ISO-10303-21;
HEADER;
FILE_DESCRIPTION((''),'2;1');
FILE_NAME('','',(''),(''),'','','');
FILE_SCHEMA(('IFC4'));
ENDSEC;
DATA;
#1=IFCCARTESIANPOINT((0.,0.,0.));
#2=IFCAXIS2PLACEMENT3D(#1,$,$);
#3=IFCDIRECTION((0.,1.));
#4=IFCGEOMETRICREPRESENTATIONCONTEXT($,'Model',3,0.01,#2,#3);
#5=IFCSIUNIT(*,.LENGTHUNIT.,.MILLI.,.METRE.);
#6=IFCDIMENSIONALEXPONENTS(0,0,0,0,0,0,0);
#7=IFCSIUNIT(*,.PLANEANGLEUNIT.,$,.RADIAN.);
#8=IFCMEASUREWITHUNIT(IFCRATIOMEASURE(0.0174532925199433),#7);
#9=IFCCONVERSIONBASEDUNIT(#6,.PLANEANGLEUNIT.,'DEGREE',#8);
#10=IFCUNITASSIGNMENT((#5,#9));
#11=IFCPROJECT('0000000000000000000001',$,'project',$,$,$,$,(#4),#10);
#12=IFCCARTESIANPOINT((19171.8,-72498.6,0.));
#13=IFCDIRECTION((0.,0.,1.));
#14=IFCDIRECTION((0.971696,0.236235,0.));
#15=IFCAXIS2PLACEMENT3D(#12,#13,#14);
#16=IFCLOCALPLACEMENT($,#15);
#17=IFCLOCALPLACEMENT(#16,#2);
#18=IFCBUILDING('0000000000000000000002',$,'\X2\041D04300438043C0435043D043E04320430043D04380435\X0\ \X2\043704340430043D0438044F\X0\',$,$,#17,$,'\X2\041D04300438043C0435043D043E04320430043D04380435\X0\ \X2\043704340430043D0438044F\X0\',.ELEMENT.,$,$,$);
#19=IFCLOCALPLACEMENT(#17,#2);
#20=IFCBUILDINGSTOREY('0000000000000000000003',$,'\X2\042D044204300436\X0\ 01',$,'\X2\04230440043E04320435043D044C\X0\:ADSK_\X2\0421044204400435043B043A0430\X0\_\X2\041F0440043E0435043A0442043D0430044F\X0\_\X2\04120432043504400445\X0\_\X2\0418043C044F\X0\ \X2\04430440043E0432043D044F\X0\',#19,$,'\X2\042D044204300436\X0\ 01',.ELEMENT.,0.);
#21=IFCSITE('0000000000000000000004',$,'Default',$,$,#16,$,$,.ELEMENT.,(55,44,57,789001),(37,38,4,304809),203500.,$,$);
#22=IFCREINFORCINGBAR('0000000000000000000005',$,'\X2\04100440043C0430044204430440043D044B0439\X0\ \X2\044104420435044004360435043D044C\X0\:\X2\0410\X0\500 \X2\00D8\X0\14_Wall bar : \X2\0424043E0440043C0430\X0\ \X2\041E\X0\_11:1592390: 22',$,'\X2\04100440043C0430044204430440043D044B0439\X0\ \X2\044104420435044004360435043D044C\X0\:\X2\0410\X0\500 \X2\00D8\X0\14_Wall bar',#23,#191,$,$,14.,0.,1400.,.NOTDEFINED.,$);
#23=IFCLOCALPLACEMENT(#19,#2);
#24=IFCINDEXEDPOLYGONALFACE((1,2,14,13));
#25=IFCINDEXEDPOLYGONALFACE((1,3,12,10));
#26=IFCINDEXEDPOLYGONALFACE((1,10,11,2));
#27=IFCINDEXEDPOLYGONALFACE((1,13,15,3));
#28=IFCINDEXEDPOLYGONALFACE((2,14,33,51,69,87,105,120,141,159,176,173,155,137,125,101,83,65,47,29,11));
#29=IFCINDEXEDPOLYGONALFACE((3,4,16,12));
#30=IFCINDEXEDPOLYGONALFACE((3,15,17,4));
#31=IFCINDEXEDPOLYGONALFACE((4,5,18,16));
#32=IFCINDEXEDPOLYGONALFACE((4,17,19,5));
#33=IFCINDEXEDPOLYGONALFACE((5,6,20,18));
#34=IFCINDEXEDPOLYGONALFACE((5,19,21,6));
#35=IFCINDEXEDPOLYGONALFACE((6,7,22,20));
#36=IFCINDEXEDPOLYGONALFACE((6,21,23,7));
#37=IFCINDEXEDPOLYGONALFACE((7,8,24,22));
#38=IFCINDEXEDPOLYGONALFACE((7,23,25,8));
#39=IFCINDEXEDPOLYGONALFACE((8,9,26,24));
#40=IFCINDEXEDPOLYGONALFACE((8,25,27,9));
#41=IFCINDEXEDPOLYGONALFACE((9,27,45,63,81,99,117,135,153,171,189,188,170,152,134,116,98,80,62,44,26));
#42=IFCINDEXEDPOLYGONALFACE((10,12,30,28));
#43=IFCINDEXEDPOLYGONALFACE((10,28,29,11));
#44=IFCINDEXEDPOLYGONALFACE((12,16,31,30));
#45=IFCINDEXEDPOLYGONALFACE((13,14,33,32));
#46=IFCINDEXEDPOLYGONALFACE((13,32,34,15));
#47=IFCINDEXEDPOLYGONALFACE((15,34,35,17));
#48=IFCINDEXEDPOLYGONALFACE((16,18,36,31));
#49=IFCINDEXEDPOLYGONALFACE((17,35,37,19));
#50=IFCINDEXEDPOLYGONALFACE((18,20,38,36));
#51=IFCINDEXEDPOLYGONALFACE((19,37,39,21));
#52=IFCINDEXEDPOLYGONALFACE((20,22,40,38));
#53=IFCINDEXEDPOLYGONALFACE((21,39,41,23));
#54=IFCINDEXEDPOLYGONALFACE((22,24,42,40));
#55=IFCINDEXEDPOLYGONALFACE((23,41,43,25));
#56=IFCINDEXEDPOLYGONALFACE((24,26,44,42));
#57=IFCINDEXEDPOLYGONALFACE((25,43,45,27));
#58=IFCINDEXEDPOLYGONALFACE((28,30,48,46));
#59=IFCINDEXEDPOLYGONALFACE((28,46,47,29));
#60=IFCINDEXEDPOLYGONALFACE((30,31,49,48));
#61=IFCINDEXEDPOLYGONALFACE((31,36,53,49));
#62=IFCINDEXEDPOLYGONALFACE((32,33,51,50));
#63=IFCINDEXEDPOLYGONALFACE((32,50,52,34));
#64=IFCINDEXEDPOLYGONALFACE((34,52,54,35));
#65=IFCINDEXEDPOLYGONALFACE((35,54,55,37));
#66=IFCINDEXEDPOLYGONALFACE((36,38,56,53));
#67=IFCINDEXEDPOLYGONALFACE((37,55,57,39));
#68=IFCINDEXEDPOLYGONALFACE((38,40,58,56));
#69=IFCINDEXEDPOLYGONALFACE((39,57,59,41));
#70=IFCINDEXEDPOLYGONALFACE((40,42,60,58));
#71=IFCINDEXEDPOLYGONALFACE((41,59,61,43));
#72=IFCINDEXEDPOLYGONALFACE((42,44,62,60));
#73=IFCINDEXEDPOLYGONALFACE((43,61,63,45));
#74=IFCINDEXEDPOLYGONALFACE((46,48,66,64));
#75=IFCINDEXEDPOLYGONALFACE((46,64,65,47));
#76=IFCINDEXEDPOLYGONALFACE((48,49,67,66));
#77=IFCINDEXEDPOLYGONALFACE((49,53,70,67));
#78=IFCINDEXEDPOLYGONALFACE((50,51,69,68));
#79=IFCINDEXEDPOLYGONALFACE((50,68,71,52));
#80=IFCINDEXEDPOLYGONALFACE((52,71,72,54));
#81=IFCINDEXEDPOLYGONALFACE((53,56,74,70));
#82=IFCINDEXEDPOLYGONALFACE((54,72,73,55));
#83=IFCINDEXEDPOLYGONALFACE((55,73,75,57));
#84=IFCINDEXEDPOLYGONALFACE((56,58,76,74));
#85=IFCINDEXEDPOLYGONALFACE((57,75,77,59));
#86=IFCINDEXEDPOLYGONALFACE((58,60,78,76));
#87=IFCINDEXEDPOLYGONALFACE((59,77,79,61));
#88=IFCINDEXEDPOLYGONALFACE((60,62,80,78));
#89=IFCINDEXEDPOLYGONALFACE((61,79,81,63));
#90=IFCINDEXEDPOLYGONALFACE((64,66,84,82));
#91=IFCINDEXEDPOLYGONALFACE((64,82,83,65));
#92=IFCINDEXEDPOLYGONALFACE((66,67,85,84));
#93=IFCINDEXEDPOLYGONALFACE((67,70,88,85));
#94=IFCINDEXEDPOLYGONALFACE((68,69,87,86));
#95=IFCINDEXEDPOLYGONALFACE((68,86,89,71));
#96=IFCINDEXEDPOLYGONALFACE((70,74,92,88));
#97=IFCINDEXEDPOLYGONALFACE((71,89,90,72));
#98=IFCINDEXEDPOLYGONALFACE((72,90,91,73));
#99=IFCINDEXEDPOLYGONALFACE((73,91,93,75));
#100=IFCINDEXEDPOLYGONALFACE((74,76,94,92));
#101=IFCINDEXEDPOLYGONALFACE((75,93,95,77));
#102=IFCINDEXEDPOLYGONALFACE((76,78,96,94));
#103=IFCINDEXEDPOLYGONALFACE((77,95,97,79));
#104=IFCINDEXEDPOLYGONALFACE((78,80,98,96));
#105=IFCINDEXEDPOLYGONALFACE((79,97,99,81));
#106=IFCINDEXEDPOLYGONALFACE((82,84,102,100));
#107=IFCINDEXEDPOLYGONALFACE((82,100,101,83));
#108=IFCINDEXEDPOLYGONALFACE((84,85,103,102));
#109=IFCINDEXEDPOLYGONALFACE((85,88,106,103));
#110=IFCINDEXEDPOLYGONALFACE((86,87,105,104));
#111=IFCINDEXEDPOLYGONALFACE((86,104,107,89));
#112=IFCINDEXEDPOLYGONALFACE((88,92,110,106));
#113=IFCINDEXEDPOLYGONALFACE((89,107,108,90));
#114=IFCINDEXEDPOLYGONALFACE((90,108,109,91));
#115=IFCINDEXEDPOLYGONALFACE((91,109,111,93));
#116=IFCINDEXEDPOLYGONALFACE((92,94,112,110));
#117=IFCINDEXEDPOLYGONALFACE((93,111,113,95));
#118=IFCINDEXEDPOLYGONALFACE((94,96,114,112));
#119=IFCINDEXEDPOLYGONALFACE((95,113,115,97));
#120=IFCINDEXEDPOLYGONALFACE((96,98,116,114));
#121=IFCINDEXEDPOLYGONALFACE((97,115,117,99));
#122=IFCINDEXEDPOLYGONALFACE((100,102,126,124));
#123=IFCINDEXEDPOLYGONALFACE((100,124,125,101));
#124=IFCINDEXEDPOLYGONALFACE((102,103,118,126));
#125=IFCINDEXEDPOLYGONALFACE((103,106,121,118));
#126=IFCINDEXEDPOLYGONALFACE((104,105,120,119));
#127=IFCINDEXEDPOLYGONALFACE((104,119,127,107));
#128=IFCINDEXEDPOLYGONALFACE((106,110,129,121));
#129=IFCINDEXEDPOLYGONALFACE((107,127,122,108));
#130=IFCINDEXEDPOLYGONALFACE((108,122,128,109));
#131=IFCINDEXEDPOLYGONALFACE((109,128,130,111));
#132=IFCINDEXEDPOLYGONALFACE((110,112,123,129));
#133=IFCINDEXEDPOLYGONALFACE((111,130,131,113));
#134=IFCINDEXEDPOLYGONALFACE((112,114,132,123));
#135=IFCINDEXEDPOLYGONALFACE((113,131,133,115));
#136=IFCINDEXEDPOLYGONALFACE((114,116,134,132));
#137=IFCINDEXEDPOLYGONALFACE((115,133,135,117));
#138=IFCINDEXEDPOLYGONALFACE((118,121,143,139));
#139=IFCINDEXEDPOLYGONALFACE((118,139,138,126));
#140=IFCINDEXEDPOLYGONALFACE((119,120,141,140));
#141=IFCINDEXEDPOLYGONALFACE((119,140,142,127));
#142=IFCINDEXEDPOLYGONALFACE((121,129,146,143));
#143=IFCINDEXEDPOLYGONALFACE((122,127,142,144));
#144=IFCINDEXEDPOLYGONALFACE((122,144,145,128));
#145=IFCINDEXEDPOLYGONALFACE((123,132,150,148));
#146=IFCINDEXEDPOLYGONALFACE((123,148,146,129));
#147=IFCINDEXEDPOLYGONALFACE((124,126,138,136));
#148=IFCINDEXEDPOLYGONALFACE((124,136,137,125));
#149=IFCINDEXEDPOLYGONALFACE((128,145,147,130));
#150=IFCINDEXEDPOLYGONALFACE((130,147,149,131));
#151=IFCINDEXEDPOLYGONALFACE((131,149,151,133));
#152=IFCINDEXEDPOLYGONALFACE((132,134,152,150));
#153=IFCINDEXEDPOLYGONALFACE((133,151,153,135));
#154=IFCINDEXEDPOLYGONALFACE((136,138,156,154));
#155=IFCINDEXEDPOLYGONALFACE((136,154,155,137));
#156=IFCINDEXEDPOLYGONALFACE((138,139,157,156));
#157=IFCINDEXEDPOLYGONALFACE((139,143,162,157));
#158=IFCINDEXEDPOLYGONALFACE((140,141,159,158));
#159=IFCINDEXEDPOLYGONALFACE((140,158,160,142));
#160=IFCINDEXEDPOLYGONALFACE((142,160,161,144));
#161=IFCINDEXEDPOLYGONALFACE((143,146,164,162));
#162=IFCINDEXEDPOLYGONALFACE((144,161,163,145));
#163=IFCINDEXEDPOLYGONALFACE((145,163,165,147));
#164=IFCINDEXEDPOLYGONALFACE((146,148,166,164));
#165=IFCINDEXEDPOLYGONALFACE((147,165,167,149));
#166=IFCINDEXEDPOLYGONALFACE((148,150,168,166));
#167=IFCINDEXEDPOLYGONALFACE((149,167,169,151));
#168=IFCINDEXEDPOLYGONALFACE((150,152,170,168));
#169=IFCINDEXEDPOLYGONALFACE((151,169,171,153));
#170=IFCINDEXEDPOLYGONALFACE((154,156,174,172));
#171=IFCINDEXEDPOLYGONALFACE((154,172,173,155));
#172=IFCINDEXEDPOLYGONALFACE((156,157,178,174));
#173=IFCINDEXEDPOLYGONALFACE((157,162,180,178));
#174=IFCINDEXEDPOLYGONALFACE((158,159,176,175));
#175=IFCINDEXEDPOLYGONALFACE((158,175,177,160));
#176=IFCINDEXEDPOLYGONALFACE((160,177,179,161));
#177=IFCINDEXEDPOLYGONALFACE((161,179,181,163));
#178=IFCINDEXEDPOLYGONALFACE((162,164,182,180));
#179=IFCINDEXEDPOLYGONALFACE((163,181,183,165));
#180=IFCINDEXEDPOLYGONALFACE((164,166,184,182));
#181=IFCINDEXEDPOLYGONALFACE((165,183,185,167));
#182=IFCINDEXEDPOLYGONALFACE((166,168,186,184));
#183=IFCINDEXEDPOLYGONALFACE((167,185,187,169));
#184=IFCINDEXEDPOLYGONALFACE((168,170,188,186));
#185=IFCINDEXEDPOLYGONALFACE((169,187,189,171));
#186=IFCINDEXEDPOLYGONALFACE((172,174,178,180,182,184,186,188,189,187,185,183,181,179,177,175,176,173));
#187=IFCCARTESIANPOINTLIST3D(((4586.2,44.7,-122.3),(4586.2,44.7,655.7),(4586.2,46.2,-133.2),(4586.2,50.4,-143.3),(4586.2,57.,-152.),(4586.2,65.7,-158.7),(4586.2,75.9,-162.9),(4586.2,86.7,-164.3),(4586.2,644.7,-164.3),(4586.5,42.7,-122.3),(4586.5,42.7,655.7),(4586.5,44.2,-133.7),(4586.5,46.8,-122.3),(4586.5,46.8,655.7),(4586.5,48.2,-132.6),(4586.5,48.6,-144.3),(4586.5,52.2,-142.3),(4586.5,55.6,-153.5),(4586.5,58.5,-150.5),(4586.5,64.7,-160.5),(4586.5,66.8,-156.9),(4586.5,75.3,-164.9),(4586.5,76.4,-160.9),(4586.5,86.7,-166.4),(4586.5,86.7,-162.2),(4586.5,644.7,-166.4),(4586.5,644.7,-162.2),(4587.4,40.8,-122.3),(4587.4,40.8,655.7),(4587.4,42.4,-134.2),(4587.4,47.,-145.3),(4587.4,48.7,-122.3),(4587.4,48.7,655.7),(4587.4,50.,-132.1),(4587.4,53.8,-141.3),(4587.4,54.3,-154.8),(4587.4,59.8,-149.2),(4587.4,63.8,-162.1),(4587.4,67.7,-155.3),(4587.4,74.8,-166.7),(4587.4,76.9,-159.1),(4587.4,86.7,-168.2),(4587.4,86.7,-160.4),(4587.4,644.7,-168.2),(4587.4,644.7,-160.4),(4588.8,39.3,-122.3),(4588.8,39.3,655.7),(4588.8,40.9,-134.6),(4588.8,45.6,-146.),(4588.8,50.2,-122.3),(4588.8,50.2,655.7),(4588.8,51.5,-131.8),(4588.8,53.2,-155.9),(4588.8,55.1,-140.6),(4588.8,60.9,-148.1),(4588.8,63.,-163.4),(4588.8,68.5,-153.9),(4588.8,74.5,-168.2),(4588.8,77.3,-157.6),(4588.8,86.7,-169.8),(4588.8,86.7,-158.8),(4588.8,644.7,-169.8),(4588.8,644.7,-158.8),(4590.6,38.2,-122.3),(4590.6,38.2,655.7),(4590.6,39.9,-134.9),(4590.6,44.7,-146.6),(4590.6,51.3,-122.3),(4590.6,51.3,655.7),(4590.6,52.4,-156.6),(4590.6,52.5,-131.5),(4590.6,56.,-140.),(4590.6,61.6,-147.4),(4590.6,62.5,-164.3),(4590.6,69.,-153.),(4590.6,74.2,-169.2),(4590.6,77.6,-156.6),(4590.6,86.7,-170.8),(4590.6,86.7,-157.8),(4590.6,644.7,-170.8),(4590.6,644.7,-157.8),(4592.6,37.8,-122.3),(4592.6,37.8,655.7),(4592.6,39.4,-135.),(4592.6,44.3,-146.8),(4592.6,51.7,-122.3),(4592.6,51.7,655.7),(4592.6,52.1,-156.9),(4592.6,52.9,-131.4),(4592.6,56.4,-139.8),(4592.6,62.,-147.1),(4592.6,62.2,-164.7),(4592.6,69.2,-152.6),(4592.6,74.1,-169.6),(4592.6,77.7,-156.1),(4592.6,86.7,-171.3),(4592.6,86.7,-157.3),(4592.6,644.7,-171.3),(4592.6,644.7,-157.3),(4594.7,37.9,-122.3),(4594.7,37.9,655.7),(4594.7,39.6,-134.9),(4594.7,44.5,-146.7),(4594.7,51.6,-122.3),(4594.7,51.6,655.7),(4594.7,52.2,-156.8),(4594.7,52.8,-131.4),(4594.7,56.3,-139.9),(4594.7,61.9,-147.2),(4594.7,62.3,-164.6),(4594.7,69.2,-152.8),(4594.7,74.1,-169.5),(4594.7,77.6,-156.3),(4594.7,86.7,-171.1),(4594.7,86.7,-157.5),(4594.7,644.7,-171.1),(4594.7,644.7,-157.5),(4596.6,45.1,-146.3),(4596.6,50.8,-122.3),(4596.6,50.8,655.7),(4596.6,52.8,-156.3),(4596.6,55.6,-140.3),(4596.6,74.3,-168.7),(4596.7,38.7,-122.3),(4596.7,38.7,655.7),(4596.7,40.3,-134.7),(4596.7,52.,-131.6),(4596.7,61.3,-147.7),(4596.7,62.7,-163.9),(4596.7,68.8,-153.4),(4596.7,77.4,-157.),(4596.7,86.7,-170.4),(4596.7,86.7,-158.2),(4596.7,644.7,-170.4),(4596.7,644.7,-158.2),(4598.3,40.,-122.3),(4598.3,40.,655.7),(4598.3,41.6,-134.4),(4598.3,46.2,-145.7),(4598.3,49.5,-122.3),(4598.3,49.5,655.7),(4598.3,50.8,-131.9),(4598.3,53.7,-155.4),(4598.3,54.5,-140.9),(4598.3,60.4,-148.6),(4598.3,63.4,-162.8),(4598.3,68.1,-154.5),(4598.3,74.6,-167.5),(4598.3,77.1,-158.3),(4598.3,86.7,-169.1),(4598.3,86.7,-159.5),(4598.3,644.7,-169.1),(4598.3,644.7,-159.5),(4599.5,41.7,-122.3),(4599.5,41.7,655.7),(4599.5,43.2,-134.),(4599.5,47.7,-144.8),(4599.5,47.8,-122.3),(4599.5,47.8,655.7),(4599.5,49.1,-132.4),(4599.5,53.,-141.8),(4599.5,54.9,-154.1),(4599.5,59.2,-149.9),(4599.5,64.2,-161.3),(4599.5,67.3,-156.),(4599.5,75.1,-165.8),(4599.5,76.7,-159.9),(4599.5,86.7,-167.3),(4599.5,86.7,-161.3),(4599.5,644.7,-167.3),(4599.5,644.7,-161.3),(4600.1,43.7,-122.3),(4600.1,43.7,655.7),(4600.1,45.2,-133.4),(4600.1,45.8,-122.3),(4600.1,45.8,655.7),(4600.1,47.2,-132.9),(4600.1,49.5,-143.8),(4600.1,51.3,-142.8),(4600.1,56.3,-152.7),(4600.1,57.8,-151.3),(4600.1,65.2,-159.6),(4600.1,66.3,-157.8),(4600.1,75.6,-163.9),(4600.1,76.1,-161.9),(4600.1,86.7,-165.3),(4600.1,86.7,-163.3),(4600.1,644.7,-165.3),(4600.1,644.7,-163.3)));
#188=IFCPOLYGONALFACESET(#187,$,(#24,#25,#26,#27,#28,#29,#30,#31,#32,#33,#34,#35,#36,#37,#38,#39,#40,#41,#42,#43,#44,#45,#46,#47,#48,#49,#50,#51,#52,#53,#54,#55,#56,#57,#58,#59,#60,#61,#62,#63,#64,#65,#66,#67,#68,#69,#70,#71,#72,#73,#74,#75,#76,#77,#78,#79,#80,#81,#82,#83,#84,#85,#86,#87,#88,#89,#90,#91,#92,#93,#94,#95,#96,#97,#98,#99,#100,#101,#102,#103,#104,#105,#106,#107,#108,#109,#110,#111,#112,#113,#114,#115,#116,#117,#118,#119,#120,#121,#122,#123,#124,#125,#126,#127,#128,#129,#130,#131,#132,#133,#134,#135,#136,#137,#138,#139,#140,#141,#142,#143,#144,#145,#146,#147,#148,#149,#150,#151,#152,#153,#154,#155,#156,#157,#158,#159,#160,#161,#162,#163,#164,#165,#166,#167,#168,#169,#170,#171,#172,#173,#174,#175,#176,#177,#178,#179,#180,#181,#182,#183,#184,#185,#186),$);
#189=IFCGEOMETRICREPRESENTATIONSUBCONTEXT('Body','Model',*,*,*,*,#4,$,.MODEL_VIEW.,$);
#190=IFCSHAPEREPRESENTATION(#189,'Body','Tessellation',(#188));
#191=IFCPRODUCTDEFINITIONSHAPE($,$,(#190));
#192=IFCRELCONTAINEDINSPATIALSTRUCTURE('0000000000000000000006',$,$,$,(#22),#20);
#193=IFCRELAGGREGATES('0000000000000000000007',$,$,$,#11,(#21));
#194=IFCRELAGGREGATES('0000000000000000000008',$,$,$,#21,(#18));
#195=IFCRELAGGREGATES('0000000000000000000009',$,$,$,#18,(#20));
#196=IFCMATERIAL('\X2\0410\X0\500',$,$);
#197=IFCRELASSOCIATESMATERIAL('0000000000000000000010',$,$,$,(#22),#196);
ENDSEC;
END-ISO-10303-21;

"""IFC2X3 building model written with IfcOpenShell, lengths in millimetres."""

from ifc_helpers import new_model, entity, si_unit, converted_unit, direction, frame, origin, place, context, subcontext, project, spatial, material, element, save


model = new_model("IFC2X3")

# Units and contexts
model_context = context("Model", 3, precision=0.01, world=origin(), true_north=direction((0.0, 1.0)))
body_context = subcontext(model_context, "Body", "Model", "MODEL_VIEW")
ifc_project = project(units=[si_unit("LENGTHUNIT", "METRE", prefix="MILLI"), converted_unit("PLANEANGLEUNIT", "DEGREE", entity("IfcRatioMeasure", 0.0174532925199433), si_unit("PLANEANGLEUNIT", "RADIAN"), dimensions=[0, 0, 0, 0, 0, 0, 0])], contexts=[model_context])

# Site, building, storey
site_placement = place(None, frame((19171.8, -72498.6, 0.0), z_axis=(0.0, 0.0, 1.0), x_axis=(0.971696, 0.236235, 0.0)))
site = spatial("IfcSite", under=ifc_project, at=site_placement, Name="Default", CompositionType="ELEMENT", RefLatitude=(55, 44, 57, 789001), RefLongitude=(37, 38, 4, 304809), RefElevation=203500.0)
building_placement = place(site_placement, origin())
building = spatial("IfcBuilding", under=site, at=building_placement, Name="Наименование здания", LongName="Наименование здания", CompositionType="ELEMENT")
storey_placement = place(building_placement, origin())
storey = spatial("IfcBuildingStorey", under=building, at=storey_placement, Name="Этаж 01", ObjectType="Уровень:ADSK_Стрелка_Проектная_Вверх_Имя уровня", LongName="Этаж 01", CompositionType="ELEMENT", Elevation=0.0)

# Reinforcing bar
ifc_material = material(Name="А500")
placement = place(storey_placement, origin())
element("IfcReinforcingBar", 1, at=placement, inside=storey, material=ifc_material, Name="Арматурный стержень:А500 Ø14_Wall bar : Форма О_11:1592390: 22", ObjectType="Арматурный стержень:А500 Ø14_Wall bar", BarLength=1400.0, BarRole="NOTDEFINED", CrossSectionArea=0.0, NominalDiameter=14.0, context=body_context, shape_type="AdvancedSweptSolid", body=[
    entity("IfcSweptDiskSolid", entity("IfcCompositeCurve", [entity("IfcCompositeCurveSegment", "CONTINUOUS", True, entity("IfcPolyline", [entity("IfcCartesianPoint", [4593.1, 44.7, 655.7]), entity("IfcCartesianPoint", [4593.1, 44.7, -122.3])])), entity("IfcCompositeCurveSegment", "CONTINUOUS", True, entity("IfcTrimmedCurve", entity("IfcCircle", entity("IfcAxis2Placement3D", entity("IfcCartesianPoint", [4593.1, 86.7, -122.3]), entity("IfcDirection", [1.0, 0.0, 0.0]), entity("IfcDirection", [0.0, 0.0, -1.0])), 42.0), [entity("IfcParameterValue", 270.0)], [entity("IfcParameterValue", 360.0)], True, "PARAMETER")), entity("IfcCompositeCurveSegment", "CONTINUOUS", True, entity("IfcPolyline", [entity("IfcCartesianPoint", [4593.1, 86.7, -164.3]), entity("IfcCartesianPoint", [4593.1, 644.7, -164.3])]))], False), 7.0, None, 0.0, 92.0),
])

save(model, "model.ifc")
